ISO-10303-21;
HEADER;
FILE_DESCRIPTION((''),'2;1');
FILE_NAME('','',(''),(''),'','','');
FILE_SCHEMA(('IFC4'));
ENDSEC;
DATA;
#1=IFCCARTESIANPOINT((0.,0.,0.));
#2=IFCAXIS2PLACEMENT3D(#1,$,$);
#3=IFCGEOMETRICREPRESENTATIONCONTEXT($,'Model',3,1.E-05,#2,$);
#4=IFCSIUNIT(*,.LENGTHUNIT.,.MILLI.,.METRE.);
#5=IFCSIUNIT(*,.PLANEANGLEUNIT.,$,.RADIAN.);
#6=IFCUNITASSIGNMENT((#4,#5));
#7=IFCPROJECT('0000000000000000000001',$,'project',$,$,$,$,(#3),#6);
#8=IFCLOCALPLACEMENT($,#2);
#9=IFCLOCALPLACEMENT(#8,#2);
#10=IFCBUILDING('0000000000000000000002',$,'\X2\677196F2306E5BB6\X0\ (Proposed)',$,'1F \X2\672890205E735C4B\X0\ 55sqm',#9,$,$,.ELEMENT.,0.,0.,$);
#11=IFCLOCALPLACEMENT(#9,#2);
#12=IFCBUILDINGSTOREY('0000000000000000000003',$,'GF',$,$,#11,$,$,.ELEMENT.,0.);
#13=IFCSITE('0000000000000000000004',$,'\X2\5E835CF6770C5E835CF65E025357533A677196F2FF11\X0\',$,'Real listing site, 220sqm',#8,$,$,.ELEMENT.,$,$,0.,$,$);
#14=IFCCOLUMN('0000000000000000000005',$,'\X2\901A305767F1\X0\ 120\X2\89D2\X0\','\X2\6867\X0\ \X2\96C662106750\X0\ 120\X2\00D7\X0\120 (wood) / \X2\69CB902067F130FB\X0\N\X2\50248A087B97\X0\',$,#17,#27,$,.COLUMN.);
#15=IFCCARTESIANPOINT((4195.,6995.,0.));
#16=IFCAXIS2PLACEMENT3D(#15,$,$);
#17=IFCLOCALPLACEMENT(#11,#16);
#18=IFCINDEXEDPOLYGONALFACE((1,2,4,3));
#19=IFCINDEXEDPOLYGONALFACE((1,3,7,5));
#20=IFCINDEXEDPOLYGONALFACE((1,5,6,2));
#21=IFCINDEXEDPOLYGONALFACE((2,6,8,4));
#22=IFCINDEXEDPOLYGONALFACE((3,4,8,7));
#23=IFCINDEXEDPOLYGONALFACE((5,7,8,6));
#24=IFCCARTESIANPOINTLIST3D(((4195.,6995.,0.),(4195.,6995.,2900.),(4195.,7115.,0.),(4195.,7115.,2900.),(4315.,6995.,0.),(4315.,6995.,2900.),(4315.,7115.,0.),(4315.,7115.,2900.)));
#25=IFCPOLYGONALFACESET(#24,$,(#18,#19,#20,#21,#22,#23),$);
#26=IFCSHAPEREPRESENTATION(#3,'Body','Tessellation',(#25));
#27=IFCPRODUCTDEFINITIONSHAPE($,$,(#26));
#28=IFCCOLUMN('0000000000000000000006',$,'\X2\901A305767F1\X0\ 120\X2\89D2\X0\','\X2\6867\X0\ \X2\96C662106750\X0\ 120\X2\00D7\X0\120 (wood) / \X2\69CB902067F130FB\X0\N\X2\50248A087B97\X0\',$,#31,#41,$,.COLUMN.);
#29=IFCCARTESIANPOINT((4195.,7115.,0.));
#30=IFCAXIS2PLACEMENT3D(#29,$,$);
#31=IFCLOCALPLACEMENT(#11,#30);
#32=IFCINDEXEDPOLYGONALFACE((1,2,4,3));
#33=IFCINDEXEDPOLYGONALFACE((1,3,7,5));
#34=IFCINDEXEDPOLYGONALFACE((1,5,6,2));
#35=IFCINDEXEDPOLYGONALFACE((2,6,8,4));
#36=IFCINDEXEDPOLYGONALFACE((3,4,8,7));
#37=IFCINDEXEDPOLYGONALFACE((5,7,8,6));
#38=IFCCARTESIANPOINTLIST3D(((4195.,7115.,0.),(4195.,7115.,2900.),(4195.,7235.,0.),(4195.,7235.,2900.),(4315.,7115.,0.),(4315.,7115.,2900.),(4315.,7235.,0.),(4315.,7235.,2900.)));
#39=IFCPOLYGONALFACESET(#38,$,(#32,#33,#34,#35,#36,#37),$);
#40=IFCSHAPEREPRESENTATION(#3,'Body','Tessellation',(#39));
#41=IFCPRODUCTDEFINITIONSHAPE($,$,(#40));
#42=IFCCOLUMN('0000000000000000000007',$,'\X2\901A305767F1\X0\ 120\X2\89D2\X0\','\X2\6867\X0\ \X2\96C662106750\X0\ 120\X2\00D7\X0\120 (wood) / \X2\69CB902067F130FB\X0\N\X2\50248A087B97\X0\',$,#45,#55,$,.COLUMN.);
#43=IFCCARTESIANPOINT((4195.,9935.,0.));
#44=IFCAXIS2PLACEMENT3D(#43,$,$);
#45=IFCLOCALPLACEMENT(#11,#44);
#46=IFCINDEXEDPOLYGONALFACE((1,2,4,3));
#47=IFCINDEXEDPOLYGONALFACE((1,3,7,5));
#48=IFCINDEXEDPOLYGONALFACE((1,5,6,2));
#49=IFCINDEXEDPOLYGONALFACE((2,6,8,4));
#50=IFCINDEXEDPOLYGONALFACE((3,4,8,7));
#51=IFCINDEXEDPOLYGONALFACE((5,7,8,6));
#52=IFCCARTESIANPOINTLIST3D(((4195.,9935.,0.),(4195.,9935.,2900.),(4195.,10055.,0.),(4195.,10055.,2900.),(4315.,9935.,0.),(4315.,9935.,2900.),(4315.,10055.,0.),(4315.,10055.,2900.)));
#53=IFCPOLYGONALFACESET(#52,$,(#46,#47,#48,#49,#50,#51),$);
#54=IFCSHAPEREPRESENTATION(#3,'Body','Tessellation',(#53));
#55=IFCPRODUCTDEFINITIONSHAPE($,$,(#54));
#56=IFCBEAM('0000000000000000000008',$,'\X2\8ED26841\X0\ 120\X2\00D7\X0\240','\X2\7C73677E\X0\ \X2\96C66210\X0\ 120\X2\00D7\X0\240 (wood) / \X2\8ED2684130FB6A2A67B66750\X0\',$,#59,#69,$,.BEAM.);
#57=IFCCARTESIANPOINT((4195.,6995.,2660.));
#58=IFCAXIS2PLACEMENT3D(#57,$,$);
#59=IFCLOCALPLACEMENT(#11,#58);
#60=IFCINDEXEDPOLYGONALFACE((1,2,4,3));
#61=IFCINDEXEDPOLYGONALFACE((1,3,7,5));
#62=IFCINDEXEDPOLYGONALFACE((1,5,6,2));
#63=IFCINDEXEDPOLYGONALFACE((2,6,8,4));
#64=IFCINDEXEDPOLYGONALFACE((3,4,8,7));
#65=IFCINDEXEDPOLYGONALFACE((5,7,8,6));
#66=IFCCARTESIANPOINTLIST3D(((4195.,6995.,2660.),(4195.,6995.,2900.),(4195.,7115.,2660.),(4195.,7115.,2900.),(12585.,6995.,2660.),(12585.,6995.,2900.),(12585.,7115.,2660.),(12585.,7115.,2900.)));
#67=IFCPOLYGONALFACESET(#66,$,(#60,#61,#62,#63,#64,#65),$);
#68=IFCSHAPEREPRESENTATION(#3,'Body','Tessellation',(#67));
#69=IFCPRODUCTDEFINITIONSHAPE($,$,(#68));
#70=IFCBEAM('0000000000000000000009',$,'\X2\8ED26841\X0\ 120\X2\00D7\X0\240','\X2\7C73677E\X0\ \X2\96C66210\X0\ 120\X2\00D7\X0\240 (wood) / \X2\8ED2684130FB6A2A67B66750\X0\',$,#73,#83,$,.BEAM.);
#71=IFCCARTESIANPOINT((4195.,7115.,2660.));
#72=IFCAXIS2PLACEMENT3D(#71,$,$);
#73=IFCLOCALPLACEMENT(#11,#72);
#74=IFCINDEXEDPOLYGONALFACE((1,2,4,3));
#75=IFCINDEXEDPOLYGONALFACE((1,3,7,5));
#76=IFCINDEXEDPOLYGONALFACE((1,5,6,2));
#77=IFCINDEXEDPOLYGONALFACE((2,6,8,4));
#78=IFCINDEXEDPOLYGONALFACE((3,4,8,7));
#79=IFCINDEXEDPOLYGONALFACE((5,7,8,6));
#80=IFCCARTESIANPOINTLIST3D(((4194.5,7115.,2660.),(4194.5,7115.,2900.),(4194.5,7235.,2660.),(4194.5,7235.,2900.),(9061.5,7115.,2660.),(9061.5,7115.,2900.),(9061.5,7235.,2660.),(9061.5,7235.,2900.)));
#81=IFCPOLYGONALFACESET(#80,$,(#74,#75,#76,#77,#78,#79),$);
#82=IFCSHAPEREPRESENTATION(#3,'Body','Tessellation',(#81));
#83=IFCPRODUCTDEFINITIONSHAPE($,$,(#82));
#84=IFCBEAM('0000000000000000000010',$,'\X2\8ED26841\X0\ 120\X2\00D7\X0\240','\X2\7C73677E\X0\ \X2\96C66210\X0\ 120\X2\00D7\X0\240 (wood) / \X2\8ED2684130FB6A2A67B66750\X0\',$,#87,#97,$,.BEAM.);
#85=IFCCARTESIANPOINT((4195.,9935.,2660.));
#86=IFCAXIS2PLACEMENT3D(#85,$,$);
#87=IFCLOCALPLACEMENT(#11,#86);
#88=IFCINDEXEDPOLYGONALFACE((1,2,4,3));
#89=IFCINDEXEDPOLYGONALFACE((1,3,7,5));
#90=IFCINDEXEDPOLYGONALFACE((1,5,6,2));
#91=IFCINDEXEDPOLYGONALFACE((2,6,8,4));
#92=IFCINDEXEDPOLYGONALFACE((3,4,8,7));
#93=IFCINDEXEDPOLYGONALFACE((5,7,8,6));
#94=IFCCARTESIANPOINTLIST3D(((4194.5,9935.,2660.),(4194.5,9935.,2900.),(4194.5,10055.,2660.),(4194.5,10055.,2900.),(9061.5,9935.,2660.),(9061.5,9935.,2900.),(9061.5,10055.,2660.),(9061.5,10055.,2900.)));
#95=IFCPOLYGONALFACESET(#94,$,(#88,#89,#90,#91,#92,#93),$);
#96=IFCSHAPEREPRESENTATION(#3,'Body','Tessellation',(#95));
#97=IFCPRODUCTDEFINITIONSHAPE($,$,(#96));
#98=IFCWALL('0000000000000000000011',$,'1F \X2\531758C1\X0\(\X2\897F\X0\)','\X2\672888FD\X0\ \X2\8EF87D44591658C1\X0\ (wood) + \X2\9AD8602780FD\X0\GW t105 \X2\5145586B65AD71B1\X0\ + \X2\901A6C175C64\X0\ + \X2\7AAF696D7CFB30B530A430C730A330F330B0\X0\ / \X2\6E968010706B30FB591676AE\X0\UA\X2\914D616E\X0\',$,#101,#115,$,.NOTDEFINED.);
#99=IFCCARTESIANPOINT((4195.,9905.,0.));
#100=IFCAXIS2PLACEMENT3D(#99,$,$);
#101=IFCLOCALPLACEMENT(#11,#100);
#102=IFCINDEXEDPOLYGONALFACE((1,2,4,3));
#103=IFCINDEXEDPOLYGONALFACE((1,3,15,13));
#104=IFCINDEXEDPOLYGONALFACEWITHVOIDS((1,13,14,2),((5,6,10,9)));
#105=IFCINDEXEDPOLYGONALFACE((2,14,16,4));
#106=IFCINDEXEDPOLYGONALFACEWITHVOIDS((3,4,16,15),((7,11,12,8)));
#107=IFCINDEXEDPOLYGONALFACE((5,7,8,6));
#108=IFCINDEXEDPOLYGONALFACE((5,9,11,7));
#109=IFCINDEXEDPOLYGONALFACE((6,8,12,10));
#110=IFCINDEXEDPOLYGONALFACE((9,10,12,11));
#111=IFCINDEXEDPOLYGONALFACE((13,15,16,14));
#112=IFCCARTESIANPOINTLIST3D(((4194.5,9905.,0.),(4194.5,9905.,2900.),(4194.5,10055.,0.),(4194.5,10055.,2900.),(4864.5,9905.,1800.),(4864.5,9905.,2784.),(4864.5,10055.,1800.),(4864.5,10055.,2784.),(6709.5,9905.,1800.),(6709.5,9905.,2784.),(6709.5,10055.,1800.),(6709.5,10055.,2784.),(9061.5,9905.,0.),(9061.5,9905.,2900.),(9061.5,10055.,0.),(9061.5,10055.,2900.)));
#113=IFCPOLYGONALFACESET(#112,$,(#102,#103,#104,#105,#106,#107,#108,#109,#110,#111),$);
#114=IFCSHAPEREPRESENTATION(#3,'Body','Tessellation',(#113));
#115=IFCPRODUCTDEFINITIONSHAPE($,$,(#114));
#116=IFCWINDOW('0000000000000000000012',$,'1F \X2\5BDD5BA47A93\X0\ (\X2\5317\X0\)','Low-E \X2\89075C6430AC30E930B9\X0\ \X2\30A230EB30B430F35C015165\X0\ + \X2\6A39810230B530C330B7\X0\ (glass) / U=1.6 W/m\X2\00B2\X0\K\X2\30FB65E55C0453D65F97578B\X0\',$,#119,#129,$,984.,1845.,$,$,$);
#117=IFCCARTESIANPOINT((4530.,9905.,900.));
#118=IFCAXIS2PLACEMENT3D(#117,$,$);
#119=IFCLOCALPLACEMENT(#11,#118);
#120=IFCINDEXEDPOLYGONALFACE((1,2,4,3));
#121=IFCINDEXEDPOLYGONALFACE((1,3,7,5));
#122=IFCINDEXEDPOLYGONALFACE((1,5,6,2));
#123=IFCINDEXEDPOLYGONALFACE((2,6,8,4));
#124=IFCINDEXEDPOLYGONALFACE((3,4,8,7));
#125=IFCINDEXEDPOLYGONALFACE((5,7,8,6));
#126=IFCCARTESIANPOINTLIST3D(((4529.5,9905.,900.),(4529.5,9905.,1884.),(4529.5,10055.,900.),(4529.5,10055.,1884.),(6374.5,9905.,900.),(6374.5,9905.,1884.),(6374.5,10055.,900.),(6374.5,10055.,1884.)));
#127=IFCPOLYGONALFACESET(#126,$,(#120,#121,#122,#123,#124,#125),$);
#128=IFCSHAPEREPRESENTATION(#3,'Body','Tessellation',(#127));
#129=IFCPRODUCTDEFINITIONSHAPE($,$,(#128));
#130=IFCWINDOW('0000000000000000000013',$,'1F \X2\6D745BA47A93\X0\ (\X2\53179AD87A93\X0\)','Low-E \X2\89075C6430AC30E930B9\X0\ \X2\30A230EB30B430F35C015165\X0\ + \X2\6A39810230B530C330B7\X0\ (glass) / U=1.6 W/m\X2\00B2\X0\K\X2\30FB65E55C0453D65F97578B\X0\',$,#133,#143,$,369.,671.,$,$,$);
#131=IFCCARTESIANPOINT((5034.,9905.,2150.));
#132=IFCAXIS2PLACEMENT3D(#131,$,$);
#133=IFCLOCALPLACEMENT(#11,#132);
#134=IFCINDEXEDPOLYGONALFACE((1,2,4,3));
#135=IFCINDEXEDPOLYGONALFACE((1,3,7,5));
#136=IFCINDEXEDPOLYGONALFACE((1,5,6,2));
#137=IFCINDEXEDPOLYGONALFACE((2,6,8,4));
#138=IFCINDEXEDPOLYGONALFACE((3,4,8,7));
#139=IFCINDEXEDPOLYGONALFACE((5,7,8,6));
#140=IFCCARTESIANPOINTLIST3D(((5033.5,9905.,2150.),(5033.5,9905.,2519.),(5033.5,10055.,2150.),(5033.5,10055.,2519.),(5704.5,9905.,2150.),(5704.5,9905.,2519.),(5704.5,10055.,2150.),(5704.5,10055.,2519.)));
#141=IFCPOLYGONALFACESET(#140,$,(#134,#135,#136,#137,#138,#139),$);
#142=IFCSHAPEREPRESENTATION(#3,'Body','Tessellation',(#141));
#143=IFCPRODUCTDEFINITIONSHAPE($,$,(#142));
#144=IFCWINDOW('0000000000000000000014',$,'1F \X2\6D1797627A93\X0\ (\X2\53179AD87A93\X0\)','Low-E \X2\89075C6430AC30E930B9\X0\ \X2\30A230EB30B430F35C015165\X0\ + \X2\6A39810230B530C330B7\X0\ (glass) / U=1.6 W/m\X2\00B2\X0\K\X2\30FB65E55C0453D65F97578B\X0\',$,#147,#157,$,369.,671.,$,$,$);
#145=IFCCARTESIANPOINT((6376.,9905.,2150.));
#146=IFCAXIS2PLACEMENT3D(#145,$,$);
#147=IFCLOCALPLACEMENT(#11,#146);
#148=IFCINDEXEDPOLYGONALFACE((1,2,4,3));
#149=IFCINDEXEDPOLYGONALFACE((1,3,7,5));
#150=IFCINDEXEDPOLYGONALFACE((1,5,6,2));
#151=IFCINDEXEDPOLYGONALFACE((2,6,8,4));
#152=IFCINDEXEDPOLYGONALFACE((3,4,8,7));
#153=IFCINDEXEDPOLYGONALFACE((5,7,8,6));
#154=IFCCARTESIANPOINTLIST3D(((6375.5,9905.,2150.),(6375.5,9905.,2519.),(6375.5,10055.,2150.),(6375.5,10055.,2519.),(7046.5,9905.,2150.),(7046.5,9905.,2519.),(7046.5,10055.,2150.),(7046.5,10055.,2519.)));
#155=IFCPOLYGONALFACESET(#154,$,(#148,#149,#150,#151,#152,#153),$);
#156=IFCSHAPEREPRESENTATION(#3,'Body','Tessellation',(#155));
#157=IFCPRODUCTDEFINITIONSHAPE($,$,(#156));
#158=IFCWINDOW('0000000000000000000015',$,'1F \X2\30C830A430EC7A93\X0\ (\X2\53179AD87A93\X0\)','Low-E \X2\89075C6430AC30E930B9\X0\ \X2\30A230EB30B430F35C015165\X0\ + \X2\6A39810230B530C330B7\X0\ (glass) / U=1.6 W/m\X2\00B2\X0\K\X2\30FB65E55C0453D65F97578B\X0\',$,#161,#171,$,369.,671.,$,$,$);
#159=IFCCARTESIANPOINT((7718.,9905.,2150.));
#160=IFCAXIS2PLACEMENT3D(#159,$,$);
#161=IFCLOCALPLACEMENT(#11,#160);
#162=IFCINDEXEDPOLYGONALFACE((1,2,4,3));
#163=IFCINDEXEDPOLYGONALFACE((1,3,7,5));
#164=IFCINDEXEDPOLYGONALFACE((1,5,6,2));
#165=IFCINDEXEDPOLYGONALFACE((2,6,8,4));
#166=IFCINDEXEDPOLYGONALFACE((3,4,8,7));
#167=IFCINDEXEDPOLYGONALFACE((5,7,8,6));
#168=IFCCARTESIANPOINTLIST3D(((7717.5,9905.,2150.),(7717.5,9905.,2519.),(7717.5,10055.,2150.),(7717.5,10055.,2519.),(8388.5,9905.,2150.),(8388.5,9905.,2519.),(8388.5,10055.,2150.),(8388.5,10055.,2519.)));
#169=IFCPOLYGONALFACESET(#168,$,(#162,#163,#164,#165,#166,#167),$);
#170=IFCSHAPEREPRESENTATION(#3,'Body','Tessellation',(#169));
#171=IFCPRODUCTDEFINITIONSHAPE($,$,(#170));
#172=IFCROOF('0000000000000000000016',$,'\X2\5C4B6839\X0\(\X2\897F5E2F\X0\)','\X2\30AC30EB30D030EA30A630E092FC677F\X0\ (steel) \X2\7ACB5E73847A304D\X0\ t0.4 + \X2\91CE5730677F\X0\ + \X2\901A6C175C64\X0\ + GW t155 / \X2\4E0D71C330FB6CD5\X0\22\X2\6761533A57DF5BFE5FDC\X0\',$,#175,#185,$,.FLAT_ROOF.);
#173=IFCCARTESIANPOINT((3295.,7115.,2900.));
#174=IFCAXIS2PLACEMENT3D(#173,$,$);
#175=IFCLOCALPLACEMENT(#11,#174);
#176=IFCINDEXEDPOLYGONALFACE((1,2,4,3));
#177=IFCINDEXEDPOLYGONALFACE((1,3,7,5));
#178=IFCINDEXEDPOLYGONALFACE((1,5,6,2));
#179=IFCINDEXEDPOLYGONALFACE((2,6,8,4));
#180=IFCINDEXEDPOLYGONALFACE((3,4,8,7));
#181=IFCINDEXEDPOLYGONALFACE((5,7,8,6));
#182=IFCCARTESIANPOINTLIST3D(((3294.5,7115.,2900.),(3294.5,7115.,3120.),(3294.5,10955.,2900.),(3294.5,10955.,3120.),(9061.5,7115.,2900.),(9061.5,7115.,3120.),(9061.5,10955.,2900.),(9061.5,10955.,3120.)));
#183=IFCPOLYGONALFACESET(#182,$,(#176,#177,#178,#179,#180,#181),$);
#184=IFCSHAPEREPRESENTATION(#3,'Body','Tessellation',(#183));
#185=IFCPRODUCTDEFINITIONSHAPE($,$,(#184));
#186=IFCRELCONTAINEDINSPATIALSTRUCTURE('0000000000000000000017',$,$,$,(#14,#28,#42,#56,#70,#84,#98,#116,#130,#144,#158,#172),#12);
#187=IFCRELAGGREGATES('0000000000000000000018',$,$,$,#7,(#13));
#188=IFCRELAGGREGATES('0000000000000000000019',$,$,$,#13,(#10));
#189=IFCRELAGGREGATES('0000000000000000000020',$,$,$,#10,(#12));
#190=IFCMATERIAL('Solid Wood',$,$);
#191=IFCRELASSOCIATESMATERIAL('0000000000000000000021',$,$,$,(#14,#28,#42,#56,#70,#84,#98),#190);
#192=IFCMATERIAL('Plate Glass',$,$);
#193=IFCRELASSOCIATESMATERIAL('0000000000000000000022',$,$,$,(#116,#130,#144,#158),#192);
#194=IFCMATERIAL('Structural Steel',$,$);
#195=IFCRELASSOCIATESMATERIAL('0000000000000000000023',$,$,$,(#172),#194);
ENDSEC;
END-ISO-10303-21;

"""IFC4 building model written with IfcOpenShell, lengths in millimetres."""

from ifc_helpers import new_model, si_unit, frame, frame_2d, origin, place, context, project, spatial, rectangle, extrude, material, element, fill, save


model = new_model("IFC4")

# Units and contexts
model_context = context("Model", 3, precision=1e-05, world=origin())
ifc_project = project(units=[si_unit("LENGTHUNIT", "METRE", prefix="MILLI"), si_unit("PLANEANGLEUNIT", "RADIAN")], contexts=[model_context])

# Site, building, storey
site_placement = place(None, origin())
site = spatial("IfcSite", under=ifc_project, at=site_placement, Name="広島県広島市南区東雲１", ObjectType="Real listing site, 220sqm", CompositionType="ELEMENT", RefElevation=0.0)
building_placement = place(site_placement, origin())
building = spatial("IfcBuilding", under=site, at=building_placement, Name="東雲の家 (Proposed)", ObjectType="1F 木造平屋 55sqm", CompositionType="ELEMENT", ElevationOfRefHeight=0.0, ElevationOfTerrain=0.0)
storey_placement = place(building_placement, origin())
storey = spatial("IfcBuildingStorey", under=building, at=storey_placement, Name="GF", CompositionType="ELEMENT", Elevation=0.0)

# Columns
ifc_material_1 = material(Name="Solid Wood")
column_1_placement = place(storey_placement, frame((4195.0, 6995.0, 0.0)))
element("IfcColumn", 1, at=column_1_placement, inside=storey, material=ifc_material_1, Name="通し柱 120角", Description="桧 集成材 120×120 (wood) / 構造柱・N値計算", PredefinedType="COLUMN", context=model_context, shape_type="SweptSolid", body=[
    extrude(rectangle(XDim=120.0, YDim=120.0, at=frame_2d((60.0, 60.0))), frame((4195.0, 6995.0, 0.0)), (0.0, 0.0, 1.0), 2900.0),
])
column_2_placement = place(storey_placement, frame((4195.0, 7115.0, 0.0)))
element("IfcColumn", 2, at=column_2_placement, inside=storey, material=ifc_material_1, Name="通し柱 120角", Description="桧 集成材 120×120 (wood) / 構造柱・N値計算", PredefinedType="COLUMN", context=model_context, shape_type="SweptSolid", body=[
    extrude(rectangle(XDim=120.0, YDim=120.0, at=frame_2d((60.0, 60.0))), frame((4195.0, 7115.0, 0.0)), (0.0, 0.0, 1.0), 2900.0),
])
column_3_placement = place(storey_placement, frame((4195.0, 9935.0, 0.0)))
element("IfcColumn", 3, at=column_3_placement, inside=storey, material=ifc_material_1, Name="通し柱 120角", Description="桧 集成材 120×120 (wood) / 構造柱・N値計算", PredefinedType="COLUMN", context=model_context, shape_type="SweptSolid", body=[
    extrude(rectangle(XDim=120.0, YDim=120.0, at=frame_2d((60.0, 60.0))), frame((4195.0, 9935.0, 0.0)), (0.0, 0.0, 1.0), 2900.0),
])

# Beams
beam_1_placement = place(storey_placement, frame((4195.0, 6995.0, 2660.0)))
element("IfcBeam", 4, at=beam_1_placement, inside=storey, material=ifc_material_1, Name="軒桁 120×240", Description="米松 集成 120×240 (wood) / 軒桁・横架材", PredefinedType="BEAM", context=model_context, shape_type="SweptSolid", body=[
    extrude(rectangle(XDim=8390.0, YDim=120.0, at=frame_2d((4195.0, 60.0))), frame((4195.0, 6995.0, 2660.0)), (0.0, 0.0, 1.0), 240.0),
])
beam_2_placement = place(storey_placement, frame((4195.0, 7115.0, 2660.0)))
element("IfcBeam", 5, at=beam_2_placement, inside=storey, material=ifc_material_1, Name="軒桁 120×240", Description="米松 集成 120×240 (wood) / 軒桁・横架材", PredefinedType="BEAM", context=model_context, shape_type="SweptSolid", body=[
    extrude(rectangle(XDim=4867.0, YDim=120.0, at=frame_2d((2433.0, 60.0))), frame((4195.0, 7115.0, 2660.0)), (0.0, 0.0, 1.0), 240.0),
])
beam_3_placement = place(storey_placement, frame((4195.0, 9935.0, 2660.0)))
element("IfcBeam", 6, at=beam_3_placement, inside=storey, material=ifc_material_1, Name="軒桁 120×240", Description="米松 集成 120×240 (wood) / 軒桁・横架材", PredefinedType="BEAM", context=model_context, shape_type="SweptSolid", body=[
    extrude(rectangle(XDim=4867.0, YDim=120.0, at=frame_2d((2433.0, 60.0))), frame((4195.0, 9935.0, 2660.0)), (0.0, 0.0, 1.0), 240.0),
])

# Wall, openings, windows
wall_1_placement = place(storey_placement, frame((4195.0, 9905.0, 0.0)))
wall_1 = element("IfcWall", 7, at=wall_1_placement, inside=storey, material=ifc_material_1, Name="1F 北壁(西)", Description="木製 軸組外壁 (wood) + 高性能GW t105 充填断熱 + 通気層 + 窯業系サイディング / 準耐火・外皮UA配慮", PredefinedType="NOTDEFINED", context=model_context, shape_type="SweptSolid", body=[
    extrude(rectangle(XDim=4867.0, YDim=150.0, at=frame_2d((2433.0, 75.0))), frame((4195.0, 9905.0, 0.0)), (0.0, 0.0, 1.0), 2900.0),
])
opening_1_placement = place(storey_placement, frame((4530.0, 9905.0, 900.0)))
opening_1 = element("IfcOpeningElement", 8, at=opening_1_placement, cuts=wall_1, PredefinedType="NOTDEFINED", context=model_context, shape_type="SweptSolid", body=[
    extrude(rectangle(XDim=1845.0, YDim=150.0, at=frame_2d((922.0, 75.0))), frame((4530.0, 9905.0, 900.0)), (0.0, 0.0, 1.0), 984.0),
])
opening_2_placement = place(storey_placement, frame((5034.0, 9905.0, 2150.0)))
opening_2 = element("IfcOpeningElement", 9, at=opening_2_placement, cuts=wall_1, PredefinedType="NOTDEFINED", context=model_context, shape_type="SweptSolid", body=[
    extrude(rectangle(XDim=671.0, YDim=150.0, at=frame_2d((335.0, 75.0))), frame((5034.0, 9905.0, 2150.0)), (0.0, 0.0, 1.0), 369.0),
])
opening_3_placement = place(storey_placement, frame((6376.0, 9905.0, 2150.0)))
opening_3 = element("IfcOpeningElement", 10, at=opening_3_placement, cuts=wall_1, PredefinedType="NOTDEFINED", context=model_context, shape_type="SweptSolid", body=[
    extrude(rectangle(XDim=671.0, YDim=150.0, at=frame_2d((335.0, 75.0))), frame((6376.0, 9905.0, 2150.0)), (0.0, 0.0, 1.0), 369.0),
])
opening_4_placement = place(storey_placement, frame((7718.0, 9905.0, 2150.0)))
opening_4 = element("IfcOpeningElement", 11, at=opening_4_placement, cuts=wall_1, PredefinedType="NOTDEFINED", context=model_context, shape_type="SweptSolid", body=[
    extrude(rectangle(XDim=671.0, YDim=150.0, at=frame_2d((335.0, 75.0))), frame((7718.0, 9905.0, 2150.0)), (0.0, 0.0, 1.0), 369.0),
])
ifc_material_2 = material(Name="Plate Glass")
window_1_placement = place(storey_placement, frame((4530.0, 9905.0, 900.0)))
window_1 = element("IfcWindow", 12, at=window_1_placement, inside=storey, material=ifc_material_2, Name="1F 寝室窓 (北)", Description="Low-E 複層ガラス アルゴン封入 + 樹脂サッシ (glass) / U=1.6 W/m²K・日射取得型", OverallHeight=984.0, OverallWidth=1845.0, context=model_context, shape_type="SweptSolid", body=[
    extrude(rectangle(XDim=1845.0, YDim=150.0, at=frame_2d((922.0, 75.0))), frame((4530.0, 9905.0, 900.0)), (0.0, 0.0, 1.0), 984.0),
])
fill(opening_1, window_1)
window_2_placement = place(storey_placement, frame((5034.0, 9905.0, 2150.0)))
window_2 = element("IfcWindow", 13, at=window_2_placement, inside=storey, material=ifc_material_2, Name="1F 浴室窓 (北高窓)", Description="Low-E 複層ガラス アルゴン封入 + 樹脂サッシ (glass) / U=1.6 W/m²K・日射取得型", OverallHeight=369.0, OverallWidth=671.0, context=model_context, shape_type="SweptSolid", body=[
    extrude(rectangle(XDim=671.0, YDim=150.0, at=frame_2d((335.0, 75.0))), frame((5034.0, 9905.0, 2150.0)), (0.0, 0.0, 1.0), 369.0),
])
fill(opening_2, window_2)
window_3_placement = place(storey_placement, frame((6376.0, 9905.0, 2150.0)))
window_3 = element("IfcWindow", 14, at=window_3_placement, inside=storey, material=ifc_material_2, Name="1F 洗面窓 (北高窓)", Description="Low-E 複層ガラス アルゴン封入 + 樹脂サッシ (glass) / U=1.6 W/m²K・日射取得型", OverallHeight=369.0, OverallWidth=671.0, context=model_context, shape_type="SweptSolid", body=[
    extrude(rectangle(XDim=671.0, YDim=150.0, at=frame_2d((335.0, 75.0))), frame((6376.0, 9905.0, 2150.0)), (0.0, 0.0, 1.0), 369.0),
])
fill(opening_3, window_3)
window_4_placement = place(storey_placement, frame((7718.0, 9905.0, 2150.0)))
window_4 = element("IfcWindow", 15, at=window_4_placement, inside=storey, material=ifc_material_2, Name="1F トイレ窓 (北高窓)", Description="Low-E 複層ガラス アルゴン封入 + 樹脂サッシ (glass) / U=1.6 W/m²K・日射取得型", OverallHeight=369.0, OverallWidth=671.0, context=model_context, shape_type="SweptSolid", body=[
    extrude(rectangle(XDim=671.0, YDim=150.0, at=frame_2d((335.0, 75.0))), frame((7718.0, 9905.0, 2150.0)), (0.0, 0.0, 1.0), 369.0),
])
fill(opening_4, window_4)

# Roof
ifc_material_3 = material(Name="Structural Steel")
roof_placement = place(storey_placement, frame((3295.0, 7115.0, 2900.0)))
element("IfcRoof", 16, at=roof_placement, inside=storey, material=ifc_material_3, Name="屋根(西帯)", Description="ガルバリウム鋼板 (steel) 立平葺き t0.4 + 野地板 + 通気層 + GW t155 / 不燃・法22条区域対応", PredefinedType="FLAT_ROOF", context=model_context, shape_type="SweptSolid", body=[
    extrude(rectangle(XDim=5767.0, YDim=3840.0, at=frame_2d((2883.0, 1920.0))), frame((3295.0, 7115.0, 2900.0)), (0.0, 0.0, 1.0), 220.0),
])

save(model, "model.ifc")
